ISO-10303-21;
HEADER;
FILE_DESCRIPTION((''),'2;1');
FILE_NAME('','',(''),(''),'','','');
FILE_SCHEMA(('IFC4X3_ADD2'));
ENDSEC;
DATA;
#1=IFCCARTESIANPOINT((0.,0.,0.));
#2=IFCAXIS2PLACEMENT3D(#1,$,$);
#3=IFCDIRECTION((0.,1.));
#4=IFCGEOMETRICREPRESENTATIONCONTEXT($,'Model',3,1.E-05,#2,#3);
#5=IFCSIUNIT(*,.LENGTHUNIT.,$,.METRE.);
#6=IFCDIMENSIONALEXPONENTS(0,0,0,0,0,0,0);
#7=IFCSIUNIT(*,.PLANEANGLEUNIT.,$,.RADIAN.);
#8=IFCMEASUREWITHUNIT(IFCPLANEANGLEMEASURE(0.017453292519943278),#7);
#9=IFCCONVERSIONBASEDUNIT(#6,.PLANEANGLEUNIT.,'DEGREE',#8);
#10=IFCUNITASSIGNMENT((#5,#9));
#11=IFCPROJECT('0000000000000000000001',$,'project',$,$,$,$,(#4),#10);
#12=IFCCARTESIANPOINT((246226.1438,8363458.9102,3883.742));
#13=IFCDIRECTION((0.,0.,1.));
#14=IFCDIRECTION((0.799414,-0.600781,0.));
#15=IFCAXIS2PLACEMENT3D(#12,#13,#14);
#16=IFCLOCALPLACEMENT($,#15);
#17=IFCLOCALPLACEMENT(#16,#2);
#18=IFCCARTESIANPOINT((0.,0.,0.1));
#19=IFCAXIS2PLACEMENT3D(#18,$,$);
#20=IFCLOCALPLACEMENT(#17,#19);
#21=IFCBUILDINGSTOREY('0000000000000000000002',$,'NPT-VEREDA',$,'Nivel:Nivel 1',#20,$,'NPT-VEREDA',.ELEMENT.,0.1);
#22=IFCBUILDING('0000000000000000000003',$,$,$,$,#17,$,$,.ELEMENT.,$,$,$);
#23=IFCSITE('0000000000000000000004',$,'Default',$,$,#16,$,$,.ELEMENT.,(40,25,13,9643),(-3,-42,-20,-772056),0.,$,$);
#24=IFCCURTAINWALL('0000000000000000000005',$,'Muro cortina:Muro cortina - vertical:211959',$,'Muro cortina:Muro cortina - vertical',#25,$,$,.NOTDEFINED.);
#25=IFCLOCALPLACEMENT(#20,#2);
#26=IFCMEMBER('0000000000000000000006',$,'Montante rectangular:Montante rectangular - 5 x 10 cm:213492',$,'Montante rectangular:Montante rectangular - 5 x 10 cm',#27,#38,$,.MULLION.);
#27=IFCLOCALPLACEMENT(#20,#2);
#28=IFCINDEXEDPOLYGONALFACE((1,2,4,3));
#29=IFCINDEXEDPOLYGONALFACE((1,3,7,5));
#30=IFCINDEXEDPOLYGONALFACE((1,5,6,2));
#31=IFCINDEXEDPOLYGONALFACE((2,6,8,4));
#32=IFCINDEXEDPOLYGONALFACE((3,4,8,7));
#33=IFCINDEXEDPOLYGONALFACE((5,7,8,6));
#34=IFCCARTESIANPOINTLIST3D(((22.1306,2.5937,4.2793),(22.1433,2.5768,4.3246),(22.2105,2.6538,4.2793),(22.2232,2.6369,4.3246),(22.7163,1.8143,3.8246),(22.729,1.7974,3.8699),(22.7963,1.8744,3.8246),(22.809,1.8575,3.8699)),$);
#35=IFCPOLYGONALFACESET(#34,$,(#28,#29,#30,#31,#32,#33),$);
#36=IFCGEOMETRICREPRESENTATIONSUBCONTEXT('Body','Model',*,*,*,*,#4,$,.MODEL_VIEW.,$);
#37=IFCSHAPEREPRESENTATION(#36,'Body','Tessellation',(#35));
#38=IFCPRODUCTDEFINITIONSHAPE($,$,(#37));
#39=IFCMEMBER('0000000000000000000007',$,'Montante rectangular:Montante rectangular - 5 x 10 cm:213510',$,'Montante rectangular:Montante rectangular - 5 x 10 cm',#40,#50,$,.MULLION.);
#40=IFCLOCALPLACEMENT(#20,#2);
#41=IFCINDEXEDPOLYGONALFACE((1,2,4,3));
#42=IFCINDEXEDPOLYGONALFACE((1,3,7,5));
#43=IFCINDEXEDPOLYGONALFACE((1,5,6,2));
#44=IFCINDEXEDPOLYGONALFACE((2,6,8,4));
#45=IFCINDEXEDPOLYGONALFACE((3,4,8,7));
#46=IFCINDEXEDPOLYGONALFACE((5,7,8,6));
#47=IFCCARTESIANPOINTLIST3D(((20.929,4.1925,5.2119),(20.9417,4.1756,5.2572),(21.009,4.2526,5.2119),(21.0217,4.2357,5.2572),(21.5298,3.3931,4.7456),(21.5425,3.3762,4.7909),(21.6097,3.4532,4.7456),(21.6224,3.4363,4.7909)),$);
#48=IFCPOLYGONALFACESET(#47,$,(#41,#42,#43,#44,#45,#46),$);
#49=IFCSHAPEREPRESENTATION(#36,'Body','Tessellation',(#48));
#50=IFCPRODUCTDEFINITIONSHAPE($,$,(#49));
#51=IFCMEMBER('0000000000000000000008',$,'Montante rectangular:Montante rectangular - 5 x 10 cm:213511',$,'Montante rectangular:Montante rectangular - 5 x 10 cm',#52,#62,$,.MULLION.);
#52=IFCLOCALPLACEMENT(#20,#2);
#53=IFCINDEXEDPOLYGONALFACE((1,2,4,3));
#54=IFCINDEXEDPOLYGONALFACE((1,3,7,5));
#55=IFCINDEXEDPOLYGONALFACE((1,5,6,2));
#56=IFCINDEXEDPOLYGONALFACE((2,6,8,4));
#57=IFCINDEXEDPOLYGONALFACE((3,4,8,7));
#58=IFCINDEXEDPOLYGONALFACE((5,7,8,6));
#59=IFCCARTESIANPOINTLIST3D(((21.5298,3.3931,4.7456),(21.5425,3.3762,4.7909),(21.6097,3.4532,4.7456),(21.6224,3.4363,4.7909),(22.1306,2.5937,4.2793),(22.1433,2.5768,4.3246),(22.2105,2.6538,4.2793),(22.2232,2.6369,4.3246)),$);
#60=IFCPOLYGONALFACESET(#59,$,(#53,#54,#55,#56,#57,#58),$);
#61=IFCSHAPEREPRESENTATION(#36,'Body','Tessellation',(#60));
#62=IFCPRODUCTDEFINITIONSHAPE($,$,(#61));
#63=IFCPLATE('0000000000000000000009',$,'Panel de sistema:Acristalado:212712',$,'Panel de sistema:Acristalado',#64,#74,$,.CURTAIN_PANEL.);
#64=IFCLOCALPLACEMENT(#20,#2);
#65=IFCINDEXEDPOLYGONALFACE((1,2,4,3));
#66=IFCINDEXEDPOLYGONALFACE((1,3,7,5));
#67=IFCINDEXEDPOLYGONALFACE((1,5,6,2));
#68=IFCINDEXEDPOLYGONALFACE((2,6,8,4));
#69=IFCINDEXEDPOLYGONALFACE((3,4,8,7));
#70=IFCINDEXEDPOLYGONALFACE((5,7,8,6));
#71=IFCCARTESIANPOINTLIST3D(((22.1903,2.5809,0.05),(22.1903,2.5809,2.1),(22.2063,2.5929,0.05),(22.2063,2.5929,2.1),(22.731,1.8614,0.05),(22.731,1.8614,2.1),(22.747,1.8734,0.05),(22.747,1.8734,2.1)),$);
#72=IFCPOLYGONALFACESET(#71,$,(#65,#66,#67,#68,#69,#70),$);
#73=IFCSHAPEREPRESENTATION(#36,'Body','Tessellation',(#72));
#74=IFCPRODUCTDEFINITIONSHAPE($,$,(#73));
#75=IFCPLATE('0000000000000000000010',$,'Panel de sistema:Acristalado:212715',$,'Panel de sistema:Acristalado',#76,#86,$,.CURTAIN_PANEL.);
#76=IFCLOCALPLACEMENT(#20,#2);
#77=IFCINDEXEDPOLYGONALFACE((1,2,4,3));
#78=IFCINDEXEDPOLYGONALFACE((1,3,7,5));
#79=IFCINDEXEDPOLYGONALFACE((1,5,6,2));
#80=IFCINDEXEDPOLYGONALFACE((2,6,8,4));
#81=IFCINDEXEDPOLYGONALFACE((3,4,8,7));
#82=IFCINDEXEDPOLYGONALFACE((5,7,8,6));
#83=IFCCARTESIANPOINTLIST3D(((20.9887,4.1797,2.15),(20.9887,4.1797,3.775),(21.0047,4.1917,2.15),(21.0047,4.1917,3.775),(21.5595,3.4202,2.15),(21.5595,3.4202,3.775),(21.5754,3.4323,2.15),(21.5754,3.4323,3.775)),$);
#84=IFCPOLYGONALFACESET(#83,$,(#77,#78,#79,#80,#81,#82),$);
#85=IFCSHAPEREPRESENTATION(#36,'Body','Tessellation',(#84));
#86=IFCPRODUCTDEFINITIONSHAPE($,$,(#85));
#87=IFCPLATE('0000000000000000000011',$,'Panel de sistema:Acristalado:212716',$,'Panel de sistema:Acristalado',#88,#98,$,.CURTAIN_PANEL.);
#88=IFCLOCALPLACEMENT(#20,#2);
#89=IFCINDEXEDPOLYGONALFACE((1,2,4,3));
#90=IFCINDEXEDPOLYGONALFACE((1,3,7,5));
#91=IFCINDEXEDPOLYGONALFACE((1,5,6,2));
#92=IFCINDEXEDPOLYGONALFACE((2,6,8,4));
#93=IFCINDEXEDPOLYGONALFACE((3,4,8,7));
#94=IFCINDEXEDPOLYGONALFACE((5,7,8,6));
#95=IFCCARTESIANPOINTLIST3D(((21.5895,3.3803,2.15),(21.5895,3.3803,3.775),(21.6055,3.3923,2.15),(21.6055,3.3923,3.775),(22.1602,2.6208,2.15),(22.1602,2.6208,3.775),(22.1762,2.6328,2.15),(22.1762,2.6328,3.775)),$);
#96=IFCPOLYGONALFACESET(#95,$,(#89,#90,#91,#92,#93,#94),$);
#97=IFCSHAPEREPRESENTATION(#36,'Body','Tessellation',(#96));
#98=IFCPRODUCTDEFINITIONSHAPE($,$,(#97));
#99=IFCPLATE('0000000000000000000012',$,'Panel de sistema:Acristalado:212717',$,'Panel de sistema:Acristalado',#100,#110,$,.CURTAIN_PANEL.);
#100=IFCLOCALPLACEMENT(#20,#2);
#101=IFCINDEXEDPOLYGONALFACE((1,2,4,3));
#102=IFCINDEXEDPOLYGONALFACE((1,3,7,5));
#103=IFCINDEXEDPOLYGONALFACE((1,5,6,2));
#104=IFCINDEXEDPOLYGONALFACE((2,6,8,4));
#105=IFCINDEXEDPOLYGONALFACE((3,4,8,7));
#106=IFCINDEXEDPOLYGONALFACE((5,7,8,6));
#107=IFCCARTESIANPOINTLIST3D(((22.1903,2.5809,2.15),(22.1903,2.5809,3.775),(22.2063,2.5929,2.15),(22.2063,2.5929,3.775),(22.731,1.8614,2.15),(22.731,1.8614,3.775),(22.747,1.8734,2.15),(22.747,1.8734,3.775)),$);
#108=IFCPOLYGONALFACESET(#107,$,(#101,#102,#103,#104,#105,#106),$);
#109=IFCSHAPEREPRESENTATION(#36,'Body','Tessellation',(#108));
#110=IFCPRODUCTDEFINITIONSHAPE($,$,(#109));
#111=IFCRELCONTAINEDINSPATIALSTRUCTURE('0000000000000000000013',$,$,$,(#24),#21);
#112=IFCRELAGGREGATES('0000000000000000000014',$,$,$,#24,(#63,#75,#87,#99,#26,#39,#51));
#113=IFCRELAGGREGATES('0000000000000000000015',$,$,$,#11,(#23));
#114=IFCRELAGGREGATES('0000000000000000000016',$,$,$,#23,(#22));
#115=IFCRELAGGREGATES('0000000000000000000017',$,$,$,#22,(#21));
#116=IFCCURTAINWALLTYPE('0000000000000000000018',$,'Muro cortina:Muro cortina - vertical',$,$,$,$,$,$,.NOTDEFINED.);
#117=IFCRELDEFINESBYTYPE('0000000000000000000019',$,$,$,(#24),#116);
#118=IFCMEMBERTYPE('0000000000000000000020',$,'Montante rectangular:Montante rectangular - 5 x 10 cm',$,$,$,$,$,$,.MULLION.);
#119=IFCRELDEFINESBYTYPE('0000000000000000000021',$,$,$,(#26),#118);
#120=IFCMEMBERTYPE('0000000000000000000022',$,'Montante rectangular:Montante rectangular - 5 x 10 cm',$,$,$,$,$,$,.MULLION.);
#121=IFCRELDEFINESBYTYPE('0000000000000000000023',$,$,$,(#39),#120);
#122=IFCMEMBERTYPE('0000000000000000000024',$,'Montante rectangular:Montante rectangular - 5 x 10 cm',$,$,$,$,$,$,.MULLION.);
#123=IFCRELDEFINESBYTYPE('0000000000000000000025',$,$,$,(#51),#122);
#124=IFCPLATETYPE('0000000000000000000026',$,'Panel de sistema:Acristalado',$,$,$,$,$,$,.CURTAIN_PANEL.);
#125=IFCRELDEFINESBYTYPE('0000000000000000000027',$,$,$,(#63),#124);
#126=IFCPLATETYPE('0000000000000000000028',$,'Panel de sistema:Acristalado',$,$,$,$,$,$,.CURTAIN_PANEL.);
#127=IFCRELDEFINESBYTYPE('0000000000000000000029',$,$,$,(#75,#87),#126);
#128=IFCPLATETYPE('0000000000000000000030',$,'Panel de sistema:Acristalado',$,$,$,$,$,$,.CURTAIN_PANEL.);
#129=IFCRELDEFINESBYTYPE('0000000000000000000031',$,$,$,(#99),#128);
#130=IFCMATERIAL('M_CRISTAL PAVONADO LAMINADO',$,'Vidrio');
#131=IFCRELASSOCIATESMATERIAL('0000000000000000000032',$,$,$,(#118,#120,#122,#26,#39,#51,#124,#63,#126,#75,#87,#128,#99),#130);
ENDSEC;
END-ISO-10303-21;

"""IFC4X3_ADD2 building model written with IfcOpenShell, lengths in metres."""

from ifc_helpers import new_model, entity, si_unit, converted_unit, direction, frame, frame_2d, origin, origin_2d_with_axis, place, context, subcontext, project, spatial, polyline, rectangle, outline, extrude, source, transform, mapped, material, material_profile, profile_set, profile_usage, type_object, type_shapes, element, aggregate, save


model = new_model("IFC4X3_ADD2")

# Units and contexts
model_context = context("Model", 3, precision=1e-05, world=origin(), true_north=direction((0.0, 1.0)))
body_context = subcontext(model_context, "Body", "Model", "MODEL_VIEW")
ifc_project = project(units=[si_unit("LENGTHUNIT", "METRE"), converted_unit("PLANEANGLEUNIT", "DEGREE", entity("IfcPlaneAngleMeasure", 0.017453292519943278), si_unit("PLANEANGLEUNIT", "RADIAN"), dimensions=[0, 0, 0, 0, 0, 0, 0])], contexts=[model_context])

# Site, building, storey
site_placement = place(None, frame((246226.1438, 8363458.9102, 3883.742), z_axis=(0.0, 0.0, 1.0), x_axis=(0.799414, -0.600781, 0.0)))
site = spatial("IfcSite", under=ifc_project, at=site_placement, Name="Default", CompositionType="ELEMENT", RefLatitude=(40, 25, 13, 9643), RefLongitude=(-3, -42, -20, -772056), RefElevation=0.0)
building_placement = place(site_placement, origin())
building = spatial("IfcBuilding", under=site, at=building_placement, CompositionType="ELEMENT")
storey_placement = place(building_placement, frame((0.0, 0.0, 0.1)))
storey = spatial("IfcBuildingStorey", under=building, at=storey_placement, Name="NPT-VEREDA", ObjectType="Nivel:Nivel 1", LongName="NPT-VEREDA", CompositionType="ELEMENT", Elevation=0.1)

# Curtain wall, members, plates
curtain_wall_type = type_object("IfcCurtainWallType", Name="Muro cortina:Muro cortina - vertical", PredefinedType="NOTDEFINED")
curtain_wall_placement = place(storey_placement, frame((0.0, 0.0, -0.1)))
curtain_wall = element("IfcCurtainWall", 1, at=curtain_wall_placement, inside=storey, type_object=curtain_wall_type, Name="Muro cortina:Muro cortina - vertical:211959", ObjectType="Muro cortina:Muro cortina - vertical", PredefinedType="NOTDEFINED")
ifc_material_1 = material(Name="M_CRISTAL PAVONADO LAMINADO", Category="Vidrio")
ifc_material_profile = material_profile(ifc_material_1, outline(polyline([(-0.9872, -0.025), (0.948, -0.025), (0.948, 0.025), (-0.9087, 0.025), (-0.9872, -0.025)])), Name="Montante rectangular - 5 x 10 cm")
ifc_profile_set = profile_set([ifc_material_profile], Name="Montante rectangular - 5 x 10 cm")
ifc_profile_usage = profile_usage(ifc_profile_set)
member_type_1 = type_object("IfcMemberType", Name="Montante rectangular:Montante rectangular - 5 x 10 cm", PredefinedType="MULLION", material=ifc_profile_set)
shared_shape_1 = source(origin(), body_context, "Body", "SweptSolid", [
    extrude(rectangle(XDim=1.0758, YDim=0.1, at=origin_2d_with_axis()), frame((-0.05, 0.0, -0.5379), z_axis=(1.0, 0.0, 0.0), x_axis=(0.0, 0.0, -1.0)), (0.0, 0.0, 1.0), 0.05),
])
type_shapes(member_type_1, [shared_shape_1])
member_1_placement = place(curtain_wall_placement, frame((22.769, 1.8274, 3.9699), z_axis=(0.544492, -0.724516, -0.422618), x_axis=(0.253901, -0.337847, 0.906308)))
member_1 = element("IfcMember", 2, at=member_1_placement, type_object=member_type_1, material=ifc_profile_usage, Name="Montante rectangular:Montante rectangular - 5 x 10 cm:213492", ObjectType="Montante rectangular:Montante rectangular - 5 x 10 cm", PredefinedType="MULLION", context=body_context, shape_type="MappedRepresentation", body=[
    mapped(shared_shape_1, transform((0.0, 0.0, 0.0), scale=1.0)),
])
member_type_2 = type_object("IfcMemberType", Name="Montante rectangular:Montante rectangular - 5 x 10 cm", PredefinedType="MULLION", material=ifc_profile_set)
shared_shape_2 = source(origin(), body_context, "Body", "SweptSolid", [
    extrude(rectangle(XDim=0.05, YDim=0.1, at=origin_2d_with_axis()), frame((-0.025, 0.0, -1.1034), z_axis=(0.0, 0.0, 1.0), x_axis=(-1.0, 0.0, 0.0)), (0.0, 0.0, 1.0), 1.1034),
])
type_shapes(member_type_2, [shared_shape_2])
member_2_placement = place(curtain_wall_placement, frame((21.5825, 3.4063, 4.8909), z_axis=(0.544492, -0.724516, -0.422618), x_axis=(0.253901, -0.337847, 0.906308)))
member_2 = element("IfcMember", 3, at=member_2_placement, type_object=member_type_2, material=ifc_profile_usage, Name="Montante rectangular:Montante rectangular - 5 x 10 cm:213510", ObjectType="Montante rectangular:Montante rectangular - 5 x 10 cm", PredefinedType="MULLION", context=body_context, shape_type="MappedRepresentation", body=[
    mapped(shared_shape_2, transform((0.0, 0.0, 0.0), scale=1.0)),
])
member_type_3 = type_object("IfcMemberType", Name="Montante rectangular:Montante rectangular - 5 x 10 cm", PredefinedType="MULLION", material=ifc_profile_set)
shared_shape_3 = source(origin(), body_context, "Body", "SweptSolid", [
    extrude(rectangle(XDim=0.05, YDim=0.1, at=origin_2d_with_axis()), frame((-0.025, 0.0, -1.1034), z_axis=(0.0, 0.0, 1.0), x_axis=(-1.0, 0.0, 0.0)), (0.0, 0.0, 1.0), 1.1034),
])
type_shapes(member_type_3, [shared_shape_3])
member_3_placement = place(curtain_wall_placement, frame((22.1832, 2.6068, 4.4246), z_axis=(0.544492, -0.724516, -0.422618), x_axis=(0.253901, -0.337847, 0.906308)))
member_3 = element("IfcMember", 4, at=member_3_placement, type_object=member_type_3, material=ifc_profile_usage, Name="Montante rectangular:Montante rectangular - 5 x 10 cm:213511", ObjectType="Montante rectangular:Montante rectangular - 5 x 10 cm", PredefinedType="MULLION", context=body_context, shape_type="MappedRepresentation", body=[
    mapped(shared_shape_3, transform((0.0, 0.0, 0.0), scale=1.0)),
])
plate_type_1 = type_object("IfcPlateType", Name="Panel de sistema:Acristalado", PredefinedType="CURTAIN_PANEL", material=ifc_material_1)
shared_shape_4 = source(origin(), body_context, "Body", "SweptSolid", [
    extrude(rectangle(XDim=0.02, YDim=0.9, at=frame_2d((0.0, 0.0), x_axis=(1.0, 0.0))), frame((0.0, 0.0, 0.0), z_axis=(0.0, 0.0, 1.0), x_axis=(0.0, 1.0, 0.0)), (0.0, 0.0, 1.0), 2.05),
])
type_shapes(plate_type_1, [shared_shape_4])
plate_1_placement = place(curtain_wall_placement, frame((22.4686, 2.2271, 0.15), z_axis=(0.0, 0.0, 1.0), x_axis=(0.60078, -0.799414, 0.0)))
plate_1 = element("IfcPlate", 5, at=plate_1_placement, type_object=plate_type_1, material=ifc_material_1, Name="Panel de sistema:Acristalado:212712", ObjectType="Panel de sistema:Acristalado", PredefinedType="CURTAIN_PANEL", context=body_context, shape_type="MappedRepresentation", body=[
    mapped(shared_shape_4, transform((0.0, 0.0, 0.0), scale=1.0)),
])
plate_type_2 = type_object("IfcPlateType", Name="Panel de sistema:Acristalado", PredefinedType="CURTAIN_PANEL", material=ifc_material_1)
shared_shape_5 = source(origin(), body_context, "Body", "SweptSolid", [
    extrude(rectangle(XDim=0.02, YDim=0.95, at=frame_2d((0.0, 0.0), x_axis=(1.0, 0.0))), frame((0.0, 0.0, 0.0), z_axis=(0.0, 0.0, 1.0), x_axis=(0.0, 1.0, 0.0)), (0.0, 0.0, 1.0), 1.625),
])
type_shapes(plate_type_2, [shared_shape_5])
plate_2_placement = place(curtain_wall_placement, frame((21.2821, 3.806, 2.25), z_axis=(0.0, 0.0, 1.0), x_axis=(0.60078, -0.799414, 0.0)))
plate_2 = element("IfcPlate", 6, at=plate_2_placement, type_object=plate_type_2, material=ifc_material_1, Name="Panel de sistema:Acristalado:212715", ObjectType="Panel de sistema:Acristalado", PredefinedType="CURTAIN_PANEL", context=body_context, shape_type="MappedRepresentation", body=[
    mapped(shared_shape_5, transform((0.0, 0.0, 0.0), scale=1.0)),
])
plate_3_placement = place(curtain_wall_placement, frame((21.8829, 3.0066, 2.25), z_axis=(0.0, 0.0, 1.0), x_axis=(0.60078, -0.799414, 0.0)))
plate_3 = element("IfcPlate", 7, at=plate_3_placement, type_object=plate_type_2, material=ifc_material_1, Name="Panel de sistema:Acristalado:212716", ObjectType="Panel de sistema:Acristalado", PredefinedType="CURTAIN_PANEL", context=body_context, shape_type="MappedRepresentation", body=[
    mapped(shared_shape_5, transform((0.0, 0.0, 0.0), scale=1.0)),
])
plate_type_3 = type_object("IfcPlateType", Name="Panel de sistema:Acristalado", PredefinedType="CURTAIN_PANEL", material=ifc_material_1)
shared_shape_6 = source(origin(), body_context, "Body", "SweptSolid", [
    extrude(rectangle(XDim=0.02, YDim=0.9, at=frame_2d((0.0, 0.0), x_axis=(1.0, 0.0))), frame((0.0, 0.0, 0.0), z_axis=(0.0, 0.0, 1.0), x_axis=(0.0, 1.0, 0.0)), (0.0, 0.0, 1.0), 1.625),
])
type_shapes(plate_type_3, [shared_shape_6])
plate_4_placement = place(curtain_wall_placement, frame((22.4686, 2.2271, 2.25), z_axis=(0.0, 0.0, 1.0), x_axis=(0.60078, -0.799414, 0.0)))
plate_4 = element("IfcPlate", 8, at=plate_4_placement, type_object=plate_type_3, material=ifc_material_1, Name="Panel de sistema:Acristalado:212717", ObjectType="Panel de sistema:Acristalado", PredefinedType="CURTAIN_PANEL", context=body_context, shape_type="MappedRepresentation", body=[
    mapped(shared_shape_6, transform((0.0, 0.0, 0.0), scale=1.0)),
])
aggregate(curtain_wall, [plate_1, plate_2, plate_3, plate_4, member_1, member_2, member_3])

save(model, "model.ifc")
